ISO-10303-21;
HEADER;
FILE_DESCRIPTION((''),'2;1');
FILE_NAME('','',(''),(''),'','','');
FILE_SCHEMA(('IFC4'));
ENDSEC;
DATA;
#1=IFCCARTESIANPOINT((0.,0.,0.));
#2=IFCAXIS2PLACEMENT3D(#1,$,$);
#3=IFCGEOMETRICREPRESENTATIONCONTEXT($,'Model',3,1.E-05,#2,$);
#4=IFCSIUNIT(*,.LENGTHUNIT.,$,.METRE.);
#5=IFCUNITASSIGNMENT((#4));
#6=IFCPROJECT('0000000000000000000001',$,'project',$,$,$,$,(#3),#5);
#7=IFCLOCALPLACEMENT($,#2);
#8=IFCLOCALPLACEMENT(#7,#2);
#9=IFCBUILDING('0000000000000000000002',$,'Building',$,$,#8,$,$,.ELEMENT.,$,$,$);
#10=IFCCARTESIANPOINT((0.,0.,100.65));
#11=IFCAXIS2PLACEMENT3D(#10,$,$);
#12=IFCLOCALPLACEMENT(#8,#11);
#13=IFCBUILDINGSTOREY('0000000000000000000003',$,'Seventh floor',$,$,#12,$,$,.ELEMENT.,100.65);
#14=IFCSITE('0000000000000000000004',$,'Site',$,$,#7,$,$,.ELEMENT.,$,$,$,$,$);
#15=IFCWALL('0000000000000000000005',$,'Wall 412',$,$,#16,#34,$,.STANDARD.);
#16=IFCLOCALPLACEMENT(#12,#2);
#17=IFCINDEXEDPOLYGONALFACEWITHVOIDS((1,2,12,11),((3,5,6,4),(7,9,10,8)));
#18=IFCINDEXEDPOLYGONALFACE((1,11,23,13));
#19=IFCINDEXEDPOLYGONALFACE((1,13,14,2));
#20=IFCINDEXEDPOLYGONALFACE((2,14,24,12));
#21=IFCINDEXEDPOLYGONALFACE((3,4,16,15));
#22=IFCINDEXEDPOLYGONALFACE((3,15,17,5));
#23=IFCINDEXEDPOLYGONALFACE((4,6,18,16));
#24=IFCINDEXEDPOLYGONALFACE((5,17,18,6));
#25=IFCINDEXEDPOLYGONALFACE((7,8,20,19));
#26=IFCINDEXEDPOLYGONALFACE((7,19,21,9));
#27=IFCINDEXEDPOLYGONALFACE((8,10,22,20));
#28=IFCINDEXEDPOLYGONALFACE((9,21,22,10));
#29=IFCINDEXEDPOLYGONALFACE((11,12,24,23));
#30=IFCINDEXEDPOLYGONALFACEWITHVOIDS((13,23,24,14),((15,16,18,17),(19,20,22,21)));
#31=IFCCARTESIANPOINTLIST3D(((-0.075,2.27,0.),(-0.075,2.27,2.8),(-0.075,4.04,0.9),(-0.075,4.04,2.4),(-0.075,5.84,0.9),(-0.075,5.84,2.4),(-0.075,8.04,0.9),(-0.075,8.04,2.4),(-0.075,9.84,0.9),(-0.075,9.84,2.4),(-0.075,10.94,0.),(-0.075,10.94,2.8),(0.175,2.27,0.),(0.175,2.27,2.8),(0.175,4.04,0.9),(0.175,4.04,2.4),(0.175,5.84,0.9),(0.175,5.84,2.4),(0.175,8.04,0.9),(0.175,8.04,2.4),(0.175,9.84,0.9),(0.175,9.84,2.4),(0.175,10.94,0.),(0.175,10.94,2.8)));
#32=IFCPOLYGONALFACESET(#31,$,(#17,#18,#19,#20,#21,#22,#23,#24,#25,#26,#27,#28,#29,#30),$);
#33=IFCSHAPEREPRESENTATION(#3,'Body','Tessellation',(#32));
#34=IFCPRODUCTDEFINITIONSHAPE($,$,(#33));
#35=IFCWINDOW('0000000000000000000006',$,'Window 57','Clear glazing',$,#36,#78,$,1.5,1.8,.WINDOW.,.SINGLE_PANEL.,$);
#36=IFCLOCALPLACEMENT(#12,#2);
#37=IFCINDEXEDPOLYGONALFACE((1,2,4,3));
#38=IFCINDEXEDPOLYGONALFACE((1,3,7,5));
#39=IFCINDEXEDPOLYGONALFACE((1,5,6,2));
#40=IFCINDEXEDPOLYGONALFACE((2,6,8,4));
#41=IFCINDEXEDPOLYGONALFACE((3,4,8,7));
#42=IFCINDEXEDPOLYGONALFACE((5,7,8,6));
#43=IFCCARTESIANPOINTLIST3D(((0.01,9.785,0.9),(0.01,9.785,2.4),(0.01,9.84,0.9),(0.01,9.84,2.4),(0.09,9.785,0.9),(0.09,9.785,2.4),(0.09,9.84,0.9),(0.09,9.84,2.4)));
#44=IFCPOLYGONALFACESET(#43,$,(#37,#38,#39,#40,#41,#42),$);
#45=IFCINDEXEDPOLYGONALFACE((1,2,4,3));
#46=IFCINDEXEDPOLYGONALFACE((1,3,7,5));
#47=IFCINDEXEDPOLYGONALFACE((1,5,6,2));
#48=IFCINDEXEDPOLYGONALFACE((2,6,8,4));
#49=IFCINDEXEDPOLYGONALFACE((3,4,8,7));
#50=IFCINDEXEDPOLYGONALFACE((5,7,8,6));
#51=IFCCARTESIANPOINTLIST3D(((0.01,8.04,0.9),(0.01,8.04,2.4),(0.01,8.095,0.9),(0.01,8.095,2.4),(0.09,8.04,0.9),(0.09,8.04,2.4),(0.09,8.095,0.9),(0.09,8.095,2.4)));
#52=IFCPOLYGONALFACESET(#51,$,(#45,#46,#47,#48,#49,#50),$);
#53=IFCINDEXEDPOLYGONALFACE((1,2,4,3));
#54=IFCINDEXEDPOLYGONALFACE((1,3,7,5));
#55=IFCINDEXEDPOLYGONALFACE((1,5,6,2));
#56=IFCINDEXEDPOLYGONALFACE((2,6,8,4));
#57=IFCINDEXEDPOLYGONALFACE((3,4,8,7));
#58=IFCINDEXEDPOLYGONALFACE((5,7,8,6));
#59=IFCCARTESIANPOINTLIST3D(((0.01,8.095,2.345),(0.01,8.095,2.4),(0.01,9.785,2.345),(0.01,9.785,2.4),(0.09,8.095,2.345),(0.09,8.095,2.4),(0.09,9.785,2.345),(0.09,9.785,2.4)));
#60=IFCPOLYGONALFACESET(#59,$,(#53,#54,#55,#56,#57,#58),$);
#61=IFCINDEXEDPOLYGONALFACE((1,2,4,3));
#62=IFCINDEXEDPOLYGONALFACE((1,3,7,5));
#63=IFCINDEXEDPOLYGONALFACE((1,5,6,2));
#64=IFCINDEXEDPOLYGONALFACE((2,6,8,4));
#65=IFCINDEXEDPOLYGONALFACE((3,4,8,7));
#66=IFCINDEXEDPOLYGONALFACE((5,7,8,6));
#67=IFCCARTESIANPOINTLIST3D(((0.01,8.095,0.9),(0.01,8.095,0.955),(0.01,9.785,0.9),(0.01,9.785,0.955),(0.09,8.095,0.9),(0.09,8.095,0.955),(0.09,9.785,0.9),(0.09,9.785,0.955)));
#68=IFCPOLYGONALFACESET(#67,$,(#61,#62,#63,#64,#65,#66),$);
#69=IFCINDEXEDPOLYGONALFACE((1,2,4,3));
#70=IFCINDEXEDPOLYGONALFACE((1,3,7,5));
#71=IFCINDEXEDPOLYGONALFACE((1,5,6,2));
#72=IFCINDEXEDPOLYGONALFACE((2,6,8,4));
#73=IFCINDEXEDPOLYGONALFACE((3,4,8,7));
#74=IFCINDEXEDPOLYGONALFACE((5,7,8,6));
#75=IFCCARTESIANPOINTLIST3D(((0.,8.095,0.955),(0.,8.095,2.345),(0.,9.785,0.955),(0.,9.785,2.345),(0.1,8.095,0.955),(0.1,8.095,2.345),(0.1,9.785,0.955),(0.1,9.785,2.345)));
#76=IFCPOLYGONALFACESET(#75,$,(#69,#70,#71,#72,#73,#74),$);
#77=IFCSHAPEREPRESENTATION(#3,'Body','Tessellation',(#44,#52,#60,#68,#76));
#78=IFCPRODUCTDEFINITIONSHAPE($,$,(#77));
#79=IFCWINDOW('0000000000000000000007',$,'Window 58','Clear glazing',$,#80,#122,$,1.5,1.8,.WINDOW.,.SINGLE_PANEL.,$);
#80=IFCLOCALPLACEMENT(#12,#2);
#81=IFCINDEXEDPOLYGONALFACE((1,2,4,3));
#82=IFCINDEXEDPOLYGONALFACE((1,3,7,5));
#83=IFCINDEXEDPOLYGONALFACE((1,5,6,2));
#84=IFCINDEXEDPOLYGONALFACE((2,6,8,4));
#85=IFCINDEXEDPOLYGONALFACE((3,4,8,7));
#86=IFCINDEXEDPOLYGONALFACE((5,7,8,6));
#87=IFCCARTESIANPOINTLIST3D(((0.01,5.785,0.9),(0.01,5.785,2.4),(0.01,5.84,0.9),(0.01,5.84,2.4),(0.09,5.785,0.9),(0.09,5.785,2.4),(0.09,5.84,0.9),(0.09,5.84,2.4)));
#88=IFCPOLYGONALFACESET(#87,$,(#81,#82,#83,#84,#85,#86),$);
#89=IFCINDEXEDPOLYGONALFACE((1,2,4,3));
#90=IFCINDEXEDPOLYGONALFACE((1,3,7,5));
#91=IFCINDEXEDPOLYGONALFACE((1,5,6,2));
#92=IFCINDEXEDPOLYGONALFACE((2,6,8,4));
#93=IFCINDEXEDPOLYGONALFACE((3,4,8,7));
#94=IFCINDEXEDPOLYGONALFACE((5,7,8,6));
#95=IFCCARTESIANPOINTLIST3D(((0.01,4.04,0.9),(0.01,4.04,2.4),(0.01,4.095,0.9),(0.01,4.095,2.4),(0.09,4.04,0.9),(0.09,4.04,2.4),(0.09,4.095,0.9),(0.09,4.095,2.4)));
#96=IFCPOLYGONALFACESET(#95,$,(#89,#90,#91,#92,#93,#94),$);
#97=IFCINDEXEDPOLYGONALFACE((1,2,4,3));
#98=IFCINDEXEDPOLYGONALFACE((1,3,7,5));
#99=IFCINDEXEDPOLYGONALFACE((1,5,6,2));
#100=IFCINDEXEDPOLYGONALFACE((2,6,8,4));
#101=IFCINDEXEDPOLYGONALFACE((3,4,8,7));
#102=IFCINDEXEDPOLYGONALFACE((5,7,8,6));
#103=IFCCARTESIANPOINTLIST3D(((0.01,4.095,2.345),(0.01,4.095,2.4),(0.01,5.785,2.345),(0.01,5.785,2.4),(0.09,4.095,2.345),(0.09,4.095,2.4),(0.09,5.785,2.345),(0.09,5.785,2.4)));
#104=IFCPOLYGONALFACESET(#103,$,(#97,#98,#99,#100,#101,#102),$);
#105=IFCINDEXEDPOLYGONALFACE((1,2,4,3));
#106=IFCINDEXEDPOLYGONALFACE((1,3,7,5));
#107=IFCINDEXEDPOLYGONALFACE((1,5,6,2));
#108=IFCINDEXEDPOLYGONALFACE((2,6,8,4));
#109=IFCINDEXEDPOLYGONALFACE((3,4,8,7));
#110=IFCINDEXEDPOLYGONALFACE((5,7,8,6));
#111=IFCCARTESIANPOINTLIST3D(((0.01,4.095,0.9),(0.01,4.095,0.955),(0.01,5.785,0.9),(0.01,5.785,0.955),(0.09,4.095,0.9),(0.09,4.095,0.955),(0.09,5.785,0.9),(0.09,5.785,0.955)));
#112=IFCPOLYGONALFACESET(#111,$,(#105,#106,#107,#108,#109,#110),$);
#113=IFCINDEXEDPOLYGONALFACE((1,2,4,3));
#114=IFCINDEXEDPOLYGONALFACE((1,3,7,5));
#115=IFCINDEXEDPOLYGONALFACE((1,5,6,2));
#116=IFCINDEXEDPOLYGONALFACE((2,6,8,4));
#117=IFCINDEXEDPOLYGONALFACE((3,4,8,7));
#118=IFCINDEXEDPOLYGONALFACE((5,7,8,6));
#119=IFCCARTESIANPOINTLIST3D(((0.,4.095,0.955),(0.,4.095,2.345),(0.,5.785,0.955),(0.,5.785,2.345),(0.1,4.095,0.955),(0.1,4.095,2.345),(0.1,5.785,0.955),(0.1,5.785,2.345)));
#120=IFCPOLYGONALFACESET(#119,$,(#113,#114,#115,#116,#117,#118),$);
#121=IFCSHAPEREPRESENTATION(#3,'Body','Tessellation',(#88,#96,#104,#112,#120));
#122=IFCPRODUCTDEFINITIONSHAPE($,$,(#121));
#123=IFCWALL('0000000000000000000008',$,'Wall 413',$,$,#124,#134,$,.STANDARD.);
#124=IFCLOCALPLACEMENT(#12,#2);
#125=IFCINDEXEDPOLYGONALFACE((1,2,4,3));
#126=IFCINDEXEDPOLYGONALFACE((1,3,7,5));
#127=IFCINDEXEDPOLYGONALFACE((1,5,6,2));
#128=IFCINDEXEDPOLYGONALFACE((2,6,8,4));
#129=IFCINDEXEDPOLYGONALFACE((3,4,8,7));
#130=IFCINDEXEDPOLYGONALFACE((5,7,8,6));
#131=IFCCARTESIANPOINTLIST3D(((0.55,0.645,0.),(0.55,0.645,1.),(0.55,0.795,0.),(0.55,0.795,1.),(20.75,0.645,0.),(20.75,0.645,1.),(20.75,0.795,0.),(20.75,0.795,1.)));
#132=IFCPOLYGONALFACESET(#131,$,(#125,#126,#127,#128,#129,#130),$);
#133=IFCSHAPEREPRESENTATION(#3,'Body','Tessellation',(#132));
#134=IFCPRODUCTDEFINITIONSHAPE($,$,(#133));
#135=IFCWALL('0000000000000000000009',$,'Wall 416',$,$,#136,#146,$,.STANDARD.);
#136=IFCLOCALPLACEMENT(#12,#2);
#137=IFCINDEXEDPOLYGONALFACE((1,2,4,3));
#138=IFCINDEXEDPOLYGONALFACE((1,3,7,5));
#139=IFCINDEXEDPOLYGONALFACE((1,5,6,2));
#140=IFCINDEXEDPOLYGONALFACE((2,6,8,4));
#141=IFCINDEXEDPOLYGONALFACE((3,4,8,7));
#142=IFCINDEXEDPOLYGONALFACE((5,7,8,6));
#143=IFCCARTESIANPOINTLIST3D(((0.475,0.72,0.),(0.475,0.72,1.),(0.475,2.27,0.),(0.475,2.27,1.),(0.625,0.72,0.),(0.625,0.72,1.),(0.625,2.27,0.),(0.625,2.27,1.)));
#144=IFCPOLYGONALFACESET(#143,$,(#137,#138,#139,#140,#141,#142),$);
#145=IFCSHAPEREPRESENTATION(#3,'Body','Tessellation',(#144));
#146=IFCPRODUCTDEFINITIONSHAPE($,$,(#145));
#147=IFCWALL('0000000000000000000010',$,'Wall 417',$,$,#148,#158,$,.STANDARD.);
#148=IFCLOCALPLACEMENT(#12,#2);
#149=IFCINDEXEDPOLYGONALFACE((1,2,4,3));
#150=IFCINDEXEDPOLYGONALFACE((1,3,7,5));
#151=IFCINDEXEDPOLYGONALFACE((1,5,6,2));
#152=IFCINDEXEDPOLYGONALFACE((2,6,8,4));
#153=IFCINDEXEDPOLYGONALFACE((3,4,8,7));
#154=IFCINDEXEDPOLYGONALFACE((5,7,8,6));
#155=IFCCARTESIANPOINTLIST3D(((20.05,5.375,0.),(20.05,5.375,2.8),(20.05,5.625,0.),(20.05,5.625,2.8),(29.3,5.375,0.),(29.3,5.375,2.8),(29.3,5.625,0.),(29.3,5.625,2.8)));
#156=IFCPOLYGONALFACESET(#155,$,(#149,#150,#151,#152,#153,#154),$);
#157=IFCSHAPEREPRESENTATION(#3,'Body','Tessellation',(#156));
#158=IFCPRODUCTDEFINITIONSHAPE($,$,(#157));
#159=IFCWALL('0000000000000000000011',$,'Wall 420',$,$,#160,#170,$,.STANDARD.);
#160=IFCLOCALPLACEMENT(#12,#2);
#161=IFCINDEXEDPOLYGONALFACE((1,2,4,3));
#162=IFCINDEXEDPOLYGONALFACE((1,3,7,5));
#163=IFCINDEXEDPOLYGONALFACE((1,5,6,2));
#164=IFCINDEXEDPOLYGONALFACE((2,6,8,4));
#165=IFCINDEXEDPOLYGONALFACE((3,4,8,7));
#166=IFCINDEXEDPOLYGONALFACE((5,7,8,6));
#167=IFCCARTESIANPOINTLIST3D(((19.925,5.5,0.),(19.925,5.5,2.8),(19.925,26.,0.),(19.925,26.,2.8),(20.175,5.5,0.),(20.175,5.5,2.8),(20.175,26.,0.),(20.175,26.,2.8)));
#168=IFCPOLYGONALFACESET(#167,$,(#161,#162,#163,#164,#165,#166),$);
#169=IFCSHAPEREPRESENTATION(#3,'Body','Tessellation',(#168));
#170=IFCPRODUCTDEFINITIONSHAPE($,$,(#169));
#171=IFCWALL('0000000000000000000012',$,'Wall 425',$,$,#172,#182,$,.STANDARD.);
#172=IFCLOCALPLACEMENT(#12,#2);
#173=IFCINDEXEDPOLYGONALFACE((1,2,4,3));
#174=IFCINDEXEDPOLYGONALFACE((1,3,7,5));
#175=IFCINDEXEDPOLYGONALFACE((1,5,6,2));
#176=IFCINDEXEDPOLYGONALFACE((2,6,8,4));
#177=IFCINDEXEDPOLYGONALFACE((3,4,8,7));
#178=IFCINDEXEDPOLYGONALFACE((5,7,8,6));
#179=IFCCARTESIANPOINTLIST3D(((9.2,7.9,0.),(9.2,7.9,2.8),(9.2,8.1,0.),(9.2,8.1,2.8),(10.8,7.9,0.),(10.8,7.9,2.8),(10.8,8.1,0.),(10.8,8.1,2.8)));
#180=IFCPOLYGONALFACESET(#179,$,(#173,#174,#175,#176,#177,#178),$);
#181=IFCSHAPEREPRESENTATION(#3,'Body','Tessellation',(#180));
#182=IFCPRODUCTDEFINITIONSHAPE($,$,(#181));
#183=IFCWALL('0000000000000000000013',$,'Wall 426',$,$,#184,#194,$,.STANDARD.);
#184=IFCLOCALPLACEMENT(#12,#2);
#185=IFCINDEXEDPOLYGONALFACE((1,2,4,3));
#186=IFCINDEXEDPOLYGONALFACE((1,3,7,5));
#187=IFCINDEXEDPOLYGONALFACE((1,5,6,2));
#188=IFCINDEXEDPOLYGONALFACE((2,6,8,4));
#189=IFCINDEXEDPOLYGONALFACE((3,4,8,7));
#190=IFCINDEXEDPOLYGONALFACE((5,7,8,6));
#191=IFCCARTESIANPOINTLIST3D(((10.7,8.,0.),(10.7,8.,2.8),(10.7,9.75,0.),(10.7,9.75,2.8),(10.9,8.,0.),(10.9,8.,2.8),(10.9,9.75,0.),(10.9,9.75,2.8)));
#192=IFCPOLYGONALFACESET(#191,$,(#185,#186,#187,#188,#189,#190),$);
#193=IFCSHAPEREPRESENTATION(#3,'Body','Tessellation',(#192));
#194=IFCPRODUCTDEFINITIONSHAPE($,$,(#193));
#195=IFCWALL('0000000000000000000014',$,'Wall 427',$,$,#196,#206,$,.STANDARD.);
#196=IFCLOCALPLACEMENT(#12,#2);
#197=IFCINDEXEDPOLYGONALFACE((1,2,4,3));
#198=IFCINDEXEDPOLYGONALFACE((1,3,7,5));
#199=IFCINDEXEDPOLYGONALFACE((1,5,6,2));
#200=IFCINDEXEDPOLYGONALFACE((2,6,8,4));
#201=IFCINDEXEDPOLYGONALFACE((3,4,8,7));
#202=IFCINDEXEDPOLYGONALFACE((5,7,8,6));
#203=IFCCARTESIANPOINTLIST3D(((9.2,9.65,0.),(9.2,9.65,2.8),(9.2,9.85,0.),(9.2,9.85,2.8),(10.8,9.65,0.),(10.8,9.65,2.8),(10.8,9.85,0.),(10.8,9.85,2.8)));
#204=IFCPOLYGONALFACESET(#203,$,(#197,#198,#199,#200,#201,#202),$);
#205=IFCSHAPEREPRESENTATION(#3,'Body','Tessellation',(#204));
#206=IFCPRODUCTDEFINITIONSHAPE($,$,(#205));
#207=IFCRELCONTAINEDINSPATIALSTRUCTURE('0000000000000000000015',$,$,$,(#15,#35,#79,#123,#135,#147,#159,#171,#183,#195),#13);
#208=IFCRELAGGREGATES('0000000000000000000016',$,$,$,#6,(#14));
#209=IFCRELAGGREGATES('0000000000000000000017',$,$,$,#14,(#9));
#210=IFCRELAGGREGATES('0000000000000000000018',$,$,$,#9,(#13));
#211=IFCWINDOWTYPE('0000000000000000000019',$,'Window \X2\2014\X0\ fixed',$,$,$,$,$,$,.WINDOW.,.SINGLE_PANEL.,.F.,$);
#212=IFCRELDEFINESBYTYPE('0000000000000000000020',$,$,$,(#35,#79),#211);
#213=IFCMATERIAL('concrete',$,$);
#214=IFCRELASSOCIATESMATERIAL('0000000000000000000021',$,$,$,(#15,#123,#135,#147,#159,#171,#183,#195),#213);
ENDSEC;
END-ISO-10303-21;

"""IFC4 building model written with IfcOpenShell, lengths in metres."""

from ifc_helpers import new_model, si_unit, frame, frame_2d, origin, place, context, project, spatial, rectangle, extrude, material, type_object, element, fill, save


model = new_model("IFC4")

# Units and contexts
model_context = context("Model", 3, precision=1e-05, world=origin())
ifc_project = project(units=[si_unit("LENGTHUNIT", "METRE")], contexts=[model_context])

# Site, building, storey
site_placement = place(None, origin())
site = spatial("IfcSite", under=ifc_project, at=site_placement, Name="Site", CompositionType="ELEMENT")
building_placement = place(site_placement, origin())
building = spatial("IfcBuilding", under=site, at=building_placement, Name="Building", CompositionType="ELEMENT")
storey_placement = place(building_placement, frame((0.0, 0.0, 100.65)))
storey = spatial("IfcBuildingStorey", under=building, at=storey_placement, Name="Seventh floor", CompositionType="ELEMENT", Elevation=100.65)

# Shared definitions
ifc_material = material(Name="concrete")

# Shared definitions
window_type = type_object("IfcWindowType", Name="Window — fixed", ParameterTakesPrecedence=False, PartitioningType="SINGLE_PANEL", PredefinedType="WINDOW")

# Wall, openings, windows
wall_1_placement = place(storey_placement, frame((0.05, 10.94, 0.0), z_axis=(0.0, 0.0, 1.0), x_axis=(0.0, -1.0, 0.0)))
wall_1 = element("IfcWall", 1, at=wall_1_placement, inside=storey, material=ifc_material, Name="Wall 412", PredefinedType="STANDARD", context=model_context, shape_type="SweptSolid", body=[
    extrude(rectangle(XDim=8.67, YDim=0.25, at=frame_2d((4.335, 0.0))), origin(), (0.0, 0.0, 1.0), 2.8),
])
opening_1_placement = place(storey_placement, frame((0.05, 9.84, 0.9), z_axis=(0.0, 0.0, 1.0), x_axis=(0.0, -1.0, 0.0)))
opening_1 = element("IfcOpeningElement", 2, at=opening_1_placement, cuts=wall_1, PredefinedType="OPENING", context=model_context, shape_type="SweptSolid", body=[
    extrude(rectangle(XDim=1.8, YDim=0.31, at=frame_2d((0.9, 0.0))), origin(), (0.0, 0.0, 1.0), 1.5),
])
opening_2_placement = place(storey_placement, frame((0.05, 5.84, 0.9), z_axis=(0.0, 0.0, 1.0), x_axis=(0.0, -1.0, 0.0)))
opening_2 = element("IfcOpeningElement", 3, at=opening_2_placement, cuts=wall_1, PredefinedType="OPENING", context=model_context, shape_type="SweptSolid", body=[
    extrude(rectangle(XDim=1.8, YDim=0.31, at=frame_2d((0.9, 0.0))), origin(), (0.0, 0.0, 1.0), 1.5),
])
window_1_placement = place(storey_placement, frame((0.05, 9.84, 0.9), z_axis=(0.0, 0.0, 1.0), x_axis=(0.0, -1.0, 0.0)))
window_1 = element("IfcWindow", 4, at=window_1_placement, inside=storey, type_object=window_type, Name="Window 57", Description="Clear glazing", OverallHeight=1.5, OverallWidth=1.8, PartitioningType="SINGLE_PANEL", PredefinedType="WINDOW", context=model_context, shape_type="SweptSolid", body=[
    extrude(rectangle(XDim=0.055, YDim=0.08, at=frame_2d((0.0275, 0.0))), origin(), (0.0, 0.0, 1.0), 1.5),
    extrude(rectangle(XDim=0.055, YDim=0.08, at=frame_2d((1.7725, 0.0))), origin(), (0.0, 0.0, 1.0), 1.5),
    extrude(rectangle(XDim=1.69, YDim=0.08, at=frame_2d((0.9, 0.0))), frame((0.0, 0.0, 1.445)), (0.0, 0.0, 1.0), 0.055),
    extrude(rectangle(XDim=1.69, YDim=0.08, at=frame_2d((0.9, 0.0))), origin(), (0.0, 0.0, 1.0), 0.055),
    extrude(rectangle(XDim=1.69, YDim=0.1, at=frame_2d((0.9, 0.0))), frame((0.0, 0.0, 0.055)), (0.0, 0.0, 1.0), 1.39),
])
fill(opening_1, window_1)
window_2_placement = place(storey_placement, frame((0.05, 5.84, 0.9), z_axis=(0.0, 0.0, 1.0), x_axis=(0.0, -1.0, 0.0)))
window_2 = element("IfcWindow", 5, at=window_2_placement, inside=storey, type_object=window_type, Name="Window 58", Description="Clear glazing", OverallHeight=1.5, OverallWidth=1.8, PartitioningType="SINGLE_PANEL", PredefinedType="WINDOW", context=model_context, shape_type="SweptSolid", body=[
    extrude(rectangle(XDim=0.055, YDim=0.08, at=frame_2d((0.0275, 0.0))), origin(), (0.0, 0.0, 1.0), 1.5),
    extrude(rectangle(XDim=0.055, YDim=0.08, at=frame_2d((1.7725, 0.0))), origin(), (0.0, 0.0, 1.0), 1.5),
    extrude(rectangle(XDim=1.69, YDim=0.08, at=frame_2d((0.9, 0.0))), frame((0.0, 0.0, 1.445)), (0.0, 0.0, 1.0), 0.055),
    extrude(rectangle(XDim=1.69, YDim=0.08, at=frame_2d((0.9, 0.0))), origin(), (0.0, 0.0, 1.0), 0.055),
    extrude(rectangle(XDim=1.69, YDim=0.1, at=frame_2d((0.9, 0.0))), frame((0.0, 0.0, 0.055)), (0.0, 0.0, 1.0), 1.39),
])
fill(opening_2, window_2)

# Walls
wall_2_placement = place(storey_placement, frame((0.55, 0.72, 0.0), z_axis=(0.0, 0.0, 1.0), x_axis=(1.0, 0.0, 0.0)))
element("IfcWall", 6, at=wall_2_placement, inside=storey, material=ifc_material, Name="Wall 413", PredefinedType="STANDARD", context=model_context, shape_type="SweptSolid", body=[
    extrude(rectangle(XDim=20.2, YDim=0.15, at=frame_2d((10.1, 0.0))), origin(), (0.0, 0.0, 1.0), 1.0),
])
wall_3_placement = place(storey_placement, frame((0.55, 2.27, 0.0), z_axis=(0.0, 0.0, 1.0), x_axis=(0.0, -1.0, 0.0)))
element("IfcWall", 7, at=wall_3_placement, inside=storey, material=ifc_material, Name="Wall 416", PredefinedType="STANDARD", context=model_context, shape_type="SweptSolid", body=[
    extrude(rectangle(XDim=1.55, YDim=0.15, at=frame_2d((0.775, 0.0))), origin(), (0.0, 0.0, 1.0), 1.0),
])
wall_4_placement = place(storey_placement, frame((20.05, 5.5, 0.0), z_axis=(0.0, 0.0, 1.0), x_axis=(1.0, 0.0, 0.0)))
element("IfcWall", 8, at=wall_4_placement, inside=storey, material=ifc_material, Name="Wall 417", PredefinedType="STANDARD", context=model_context, shape_type="SweptSolid", body=[
    extrude(rectangle(XDim=9.25, YDim=0.25, at=frame_2d((4.625, 0.0))), origin(), (0.0, 0.0, 1.0), 2.8),
])
wall_5_placement = place(storey_placement, frame((20.05, 26.0, 0.0), z_axis=(0.0, 0.0, 1.0), x_axis=(0.0, -1.0, 0.0)))
element("IfcWall", 9, at=wall_5_placement, inside=storey, material=ifc_material, Name="Wall 420", PredefinedType="STANDARD", context=model_context, shape_type="SweptSolid", body=[
    extrude(rectangle(XDim=20.5, YDim=0.25, at=frame_2d((10.25, 0.0))), origin(), (0.0, 0.0, 1.0), 2.8),
])
wall_6_placement = place(storey_placement, frame((9.2, 8.0, 0.0), z_axis=(0.0, 0.0, 1.0), x_axis=(1.0, 0.0, 0.0)))
element("IfcWall", 10, at=wall_6_placement, inside=storey, material=ifc_material, Name="Wall 425", PredefinedType="STANDARD", context=model_context, shape_type="SweptSolid", body=[
    extrude(rectangle(XDim=1.6, YDim=0.2, at=frame_2d((0.8, 0.0))), origin(), (0.0, 0.0, 1.0), 2.8),
])
wall_7_placement = place(storey_placement, frame((10.8, 8.0, 0.0), z_axis=(0.0, 0.0, 1.0), x_axis=(0.0, 1.0, 0.0)))
element("IfcWall", 11, at=wall_7_placement, inside=storey, material=ifc_material, Name="Wall 426", PredefinedType="STANDARD", context=model_context, shape_type="SweptSolid", body=[
    extrude(rectangle(XDim=1.75, YDim=0.2, at=frame_2d((0.875, 0.0))), origin(), (0.0, 0.0, 1.0), 2.8),
])
wall_8_placement = place(storey_placement, frame((10.8, 9.75, 0.0), z_axis=(0.0, 0.0, 1.0), x_axis=(-1.0, 0.0, 0.0)))
element("IfcWall", 12, at=wall_8_placement, inside=storey, material=ifc_material, Name="Wall 427", PredefinedType="STANDARD", context=model_context, shape_type="SweptSolid", body=[
    extrude(rectangle(XDim=1.6, YDim=0.2, at=frame_2d((0.8, 0.0))), origin(), (0.0, 0.0, 1.0), 2.8),
])

save(model, "model.ifc")
